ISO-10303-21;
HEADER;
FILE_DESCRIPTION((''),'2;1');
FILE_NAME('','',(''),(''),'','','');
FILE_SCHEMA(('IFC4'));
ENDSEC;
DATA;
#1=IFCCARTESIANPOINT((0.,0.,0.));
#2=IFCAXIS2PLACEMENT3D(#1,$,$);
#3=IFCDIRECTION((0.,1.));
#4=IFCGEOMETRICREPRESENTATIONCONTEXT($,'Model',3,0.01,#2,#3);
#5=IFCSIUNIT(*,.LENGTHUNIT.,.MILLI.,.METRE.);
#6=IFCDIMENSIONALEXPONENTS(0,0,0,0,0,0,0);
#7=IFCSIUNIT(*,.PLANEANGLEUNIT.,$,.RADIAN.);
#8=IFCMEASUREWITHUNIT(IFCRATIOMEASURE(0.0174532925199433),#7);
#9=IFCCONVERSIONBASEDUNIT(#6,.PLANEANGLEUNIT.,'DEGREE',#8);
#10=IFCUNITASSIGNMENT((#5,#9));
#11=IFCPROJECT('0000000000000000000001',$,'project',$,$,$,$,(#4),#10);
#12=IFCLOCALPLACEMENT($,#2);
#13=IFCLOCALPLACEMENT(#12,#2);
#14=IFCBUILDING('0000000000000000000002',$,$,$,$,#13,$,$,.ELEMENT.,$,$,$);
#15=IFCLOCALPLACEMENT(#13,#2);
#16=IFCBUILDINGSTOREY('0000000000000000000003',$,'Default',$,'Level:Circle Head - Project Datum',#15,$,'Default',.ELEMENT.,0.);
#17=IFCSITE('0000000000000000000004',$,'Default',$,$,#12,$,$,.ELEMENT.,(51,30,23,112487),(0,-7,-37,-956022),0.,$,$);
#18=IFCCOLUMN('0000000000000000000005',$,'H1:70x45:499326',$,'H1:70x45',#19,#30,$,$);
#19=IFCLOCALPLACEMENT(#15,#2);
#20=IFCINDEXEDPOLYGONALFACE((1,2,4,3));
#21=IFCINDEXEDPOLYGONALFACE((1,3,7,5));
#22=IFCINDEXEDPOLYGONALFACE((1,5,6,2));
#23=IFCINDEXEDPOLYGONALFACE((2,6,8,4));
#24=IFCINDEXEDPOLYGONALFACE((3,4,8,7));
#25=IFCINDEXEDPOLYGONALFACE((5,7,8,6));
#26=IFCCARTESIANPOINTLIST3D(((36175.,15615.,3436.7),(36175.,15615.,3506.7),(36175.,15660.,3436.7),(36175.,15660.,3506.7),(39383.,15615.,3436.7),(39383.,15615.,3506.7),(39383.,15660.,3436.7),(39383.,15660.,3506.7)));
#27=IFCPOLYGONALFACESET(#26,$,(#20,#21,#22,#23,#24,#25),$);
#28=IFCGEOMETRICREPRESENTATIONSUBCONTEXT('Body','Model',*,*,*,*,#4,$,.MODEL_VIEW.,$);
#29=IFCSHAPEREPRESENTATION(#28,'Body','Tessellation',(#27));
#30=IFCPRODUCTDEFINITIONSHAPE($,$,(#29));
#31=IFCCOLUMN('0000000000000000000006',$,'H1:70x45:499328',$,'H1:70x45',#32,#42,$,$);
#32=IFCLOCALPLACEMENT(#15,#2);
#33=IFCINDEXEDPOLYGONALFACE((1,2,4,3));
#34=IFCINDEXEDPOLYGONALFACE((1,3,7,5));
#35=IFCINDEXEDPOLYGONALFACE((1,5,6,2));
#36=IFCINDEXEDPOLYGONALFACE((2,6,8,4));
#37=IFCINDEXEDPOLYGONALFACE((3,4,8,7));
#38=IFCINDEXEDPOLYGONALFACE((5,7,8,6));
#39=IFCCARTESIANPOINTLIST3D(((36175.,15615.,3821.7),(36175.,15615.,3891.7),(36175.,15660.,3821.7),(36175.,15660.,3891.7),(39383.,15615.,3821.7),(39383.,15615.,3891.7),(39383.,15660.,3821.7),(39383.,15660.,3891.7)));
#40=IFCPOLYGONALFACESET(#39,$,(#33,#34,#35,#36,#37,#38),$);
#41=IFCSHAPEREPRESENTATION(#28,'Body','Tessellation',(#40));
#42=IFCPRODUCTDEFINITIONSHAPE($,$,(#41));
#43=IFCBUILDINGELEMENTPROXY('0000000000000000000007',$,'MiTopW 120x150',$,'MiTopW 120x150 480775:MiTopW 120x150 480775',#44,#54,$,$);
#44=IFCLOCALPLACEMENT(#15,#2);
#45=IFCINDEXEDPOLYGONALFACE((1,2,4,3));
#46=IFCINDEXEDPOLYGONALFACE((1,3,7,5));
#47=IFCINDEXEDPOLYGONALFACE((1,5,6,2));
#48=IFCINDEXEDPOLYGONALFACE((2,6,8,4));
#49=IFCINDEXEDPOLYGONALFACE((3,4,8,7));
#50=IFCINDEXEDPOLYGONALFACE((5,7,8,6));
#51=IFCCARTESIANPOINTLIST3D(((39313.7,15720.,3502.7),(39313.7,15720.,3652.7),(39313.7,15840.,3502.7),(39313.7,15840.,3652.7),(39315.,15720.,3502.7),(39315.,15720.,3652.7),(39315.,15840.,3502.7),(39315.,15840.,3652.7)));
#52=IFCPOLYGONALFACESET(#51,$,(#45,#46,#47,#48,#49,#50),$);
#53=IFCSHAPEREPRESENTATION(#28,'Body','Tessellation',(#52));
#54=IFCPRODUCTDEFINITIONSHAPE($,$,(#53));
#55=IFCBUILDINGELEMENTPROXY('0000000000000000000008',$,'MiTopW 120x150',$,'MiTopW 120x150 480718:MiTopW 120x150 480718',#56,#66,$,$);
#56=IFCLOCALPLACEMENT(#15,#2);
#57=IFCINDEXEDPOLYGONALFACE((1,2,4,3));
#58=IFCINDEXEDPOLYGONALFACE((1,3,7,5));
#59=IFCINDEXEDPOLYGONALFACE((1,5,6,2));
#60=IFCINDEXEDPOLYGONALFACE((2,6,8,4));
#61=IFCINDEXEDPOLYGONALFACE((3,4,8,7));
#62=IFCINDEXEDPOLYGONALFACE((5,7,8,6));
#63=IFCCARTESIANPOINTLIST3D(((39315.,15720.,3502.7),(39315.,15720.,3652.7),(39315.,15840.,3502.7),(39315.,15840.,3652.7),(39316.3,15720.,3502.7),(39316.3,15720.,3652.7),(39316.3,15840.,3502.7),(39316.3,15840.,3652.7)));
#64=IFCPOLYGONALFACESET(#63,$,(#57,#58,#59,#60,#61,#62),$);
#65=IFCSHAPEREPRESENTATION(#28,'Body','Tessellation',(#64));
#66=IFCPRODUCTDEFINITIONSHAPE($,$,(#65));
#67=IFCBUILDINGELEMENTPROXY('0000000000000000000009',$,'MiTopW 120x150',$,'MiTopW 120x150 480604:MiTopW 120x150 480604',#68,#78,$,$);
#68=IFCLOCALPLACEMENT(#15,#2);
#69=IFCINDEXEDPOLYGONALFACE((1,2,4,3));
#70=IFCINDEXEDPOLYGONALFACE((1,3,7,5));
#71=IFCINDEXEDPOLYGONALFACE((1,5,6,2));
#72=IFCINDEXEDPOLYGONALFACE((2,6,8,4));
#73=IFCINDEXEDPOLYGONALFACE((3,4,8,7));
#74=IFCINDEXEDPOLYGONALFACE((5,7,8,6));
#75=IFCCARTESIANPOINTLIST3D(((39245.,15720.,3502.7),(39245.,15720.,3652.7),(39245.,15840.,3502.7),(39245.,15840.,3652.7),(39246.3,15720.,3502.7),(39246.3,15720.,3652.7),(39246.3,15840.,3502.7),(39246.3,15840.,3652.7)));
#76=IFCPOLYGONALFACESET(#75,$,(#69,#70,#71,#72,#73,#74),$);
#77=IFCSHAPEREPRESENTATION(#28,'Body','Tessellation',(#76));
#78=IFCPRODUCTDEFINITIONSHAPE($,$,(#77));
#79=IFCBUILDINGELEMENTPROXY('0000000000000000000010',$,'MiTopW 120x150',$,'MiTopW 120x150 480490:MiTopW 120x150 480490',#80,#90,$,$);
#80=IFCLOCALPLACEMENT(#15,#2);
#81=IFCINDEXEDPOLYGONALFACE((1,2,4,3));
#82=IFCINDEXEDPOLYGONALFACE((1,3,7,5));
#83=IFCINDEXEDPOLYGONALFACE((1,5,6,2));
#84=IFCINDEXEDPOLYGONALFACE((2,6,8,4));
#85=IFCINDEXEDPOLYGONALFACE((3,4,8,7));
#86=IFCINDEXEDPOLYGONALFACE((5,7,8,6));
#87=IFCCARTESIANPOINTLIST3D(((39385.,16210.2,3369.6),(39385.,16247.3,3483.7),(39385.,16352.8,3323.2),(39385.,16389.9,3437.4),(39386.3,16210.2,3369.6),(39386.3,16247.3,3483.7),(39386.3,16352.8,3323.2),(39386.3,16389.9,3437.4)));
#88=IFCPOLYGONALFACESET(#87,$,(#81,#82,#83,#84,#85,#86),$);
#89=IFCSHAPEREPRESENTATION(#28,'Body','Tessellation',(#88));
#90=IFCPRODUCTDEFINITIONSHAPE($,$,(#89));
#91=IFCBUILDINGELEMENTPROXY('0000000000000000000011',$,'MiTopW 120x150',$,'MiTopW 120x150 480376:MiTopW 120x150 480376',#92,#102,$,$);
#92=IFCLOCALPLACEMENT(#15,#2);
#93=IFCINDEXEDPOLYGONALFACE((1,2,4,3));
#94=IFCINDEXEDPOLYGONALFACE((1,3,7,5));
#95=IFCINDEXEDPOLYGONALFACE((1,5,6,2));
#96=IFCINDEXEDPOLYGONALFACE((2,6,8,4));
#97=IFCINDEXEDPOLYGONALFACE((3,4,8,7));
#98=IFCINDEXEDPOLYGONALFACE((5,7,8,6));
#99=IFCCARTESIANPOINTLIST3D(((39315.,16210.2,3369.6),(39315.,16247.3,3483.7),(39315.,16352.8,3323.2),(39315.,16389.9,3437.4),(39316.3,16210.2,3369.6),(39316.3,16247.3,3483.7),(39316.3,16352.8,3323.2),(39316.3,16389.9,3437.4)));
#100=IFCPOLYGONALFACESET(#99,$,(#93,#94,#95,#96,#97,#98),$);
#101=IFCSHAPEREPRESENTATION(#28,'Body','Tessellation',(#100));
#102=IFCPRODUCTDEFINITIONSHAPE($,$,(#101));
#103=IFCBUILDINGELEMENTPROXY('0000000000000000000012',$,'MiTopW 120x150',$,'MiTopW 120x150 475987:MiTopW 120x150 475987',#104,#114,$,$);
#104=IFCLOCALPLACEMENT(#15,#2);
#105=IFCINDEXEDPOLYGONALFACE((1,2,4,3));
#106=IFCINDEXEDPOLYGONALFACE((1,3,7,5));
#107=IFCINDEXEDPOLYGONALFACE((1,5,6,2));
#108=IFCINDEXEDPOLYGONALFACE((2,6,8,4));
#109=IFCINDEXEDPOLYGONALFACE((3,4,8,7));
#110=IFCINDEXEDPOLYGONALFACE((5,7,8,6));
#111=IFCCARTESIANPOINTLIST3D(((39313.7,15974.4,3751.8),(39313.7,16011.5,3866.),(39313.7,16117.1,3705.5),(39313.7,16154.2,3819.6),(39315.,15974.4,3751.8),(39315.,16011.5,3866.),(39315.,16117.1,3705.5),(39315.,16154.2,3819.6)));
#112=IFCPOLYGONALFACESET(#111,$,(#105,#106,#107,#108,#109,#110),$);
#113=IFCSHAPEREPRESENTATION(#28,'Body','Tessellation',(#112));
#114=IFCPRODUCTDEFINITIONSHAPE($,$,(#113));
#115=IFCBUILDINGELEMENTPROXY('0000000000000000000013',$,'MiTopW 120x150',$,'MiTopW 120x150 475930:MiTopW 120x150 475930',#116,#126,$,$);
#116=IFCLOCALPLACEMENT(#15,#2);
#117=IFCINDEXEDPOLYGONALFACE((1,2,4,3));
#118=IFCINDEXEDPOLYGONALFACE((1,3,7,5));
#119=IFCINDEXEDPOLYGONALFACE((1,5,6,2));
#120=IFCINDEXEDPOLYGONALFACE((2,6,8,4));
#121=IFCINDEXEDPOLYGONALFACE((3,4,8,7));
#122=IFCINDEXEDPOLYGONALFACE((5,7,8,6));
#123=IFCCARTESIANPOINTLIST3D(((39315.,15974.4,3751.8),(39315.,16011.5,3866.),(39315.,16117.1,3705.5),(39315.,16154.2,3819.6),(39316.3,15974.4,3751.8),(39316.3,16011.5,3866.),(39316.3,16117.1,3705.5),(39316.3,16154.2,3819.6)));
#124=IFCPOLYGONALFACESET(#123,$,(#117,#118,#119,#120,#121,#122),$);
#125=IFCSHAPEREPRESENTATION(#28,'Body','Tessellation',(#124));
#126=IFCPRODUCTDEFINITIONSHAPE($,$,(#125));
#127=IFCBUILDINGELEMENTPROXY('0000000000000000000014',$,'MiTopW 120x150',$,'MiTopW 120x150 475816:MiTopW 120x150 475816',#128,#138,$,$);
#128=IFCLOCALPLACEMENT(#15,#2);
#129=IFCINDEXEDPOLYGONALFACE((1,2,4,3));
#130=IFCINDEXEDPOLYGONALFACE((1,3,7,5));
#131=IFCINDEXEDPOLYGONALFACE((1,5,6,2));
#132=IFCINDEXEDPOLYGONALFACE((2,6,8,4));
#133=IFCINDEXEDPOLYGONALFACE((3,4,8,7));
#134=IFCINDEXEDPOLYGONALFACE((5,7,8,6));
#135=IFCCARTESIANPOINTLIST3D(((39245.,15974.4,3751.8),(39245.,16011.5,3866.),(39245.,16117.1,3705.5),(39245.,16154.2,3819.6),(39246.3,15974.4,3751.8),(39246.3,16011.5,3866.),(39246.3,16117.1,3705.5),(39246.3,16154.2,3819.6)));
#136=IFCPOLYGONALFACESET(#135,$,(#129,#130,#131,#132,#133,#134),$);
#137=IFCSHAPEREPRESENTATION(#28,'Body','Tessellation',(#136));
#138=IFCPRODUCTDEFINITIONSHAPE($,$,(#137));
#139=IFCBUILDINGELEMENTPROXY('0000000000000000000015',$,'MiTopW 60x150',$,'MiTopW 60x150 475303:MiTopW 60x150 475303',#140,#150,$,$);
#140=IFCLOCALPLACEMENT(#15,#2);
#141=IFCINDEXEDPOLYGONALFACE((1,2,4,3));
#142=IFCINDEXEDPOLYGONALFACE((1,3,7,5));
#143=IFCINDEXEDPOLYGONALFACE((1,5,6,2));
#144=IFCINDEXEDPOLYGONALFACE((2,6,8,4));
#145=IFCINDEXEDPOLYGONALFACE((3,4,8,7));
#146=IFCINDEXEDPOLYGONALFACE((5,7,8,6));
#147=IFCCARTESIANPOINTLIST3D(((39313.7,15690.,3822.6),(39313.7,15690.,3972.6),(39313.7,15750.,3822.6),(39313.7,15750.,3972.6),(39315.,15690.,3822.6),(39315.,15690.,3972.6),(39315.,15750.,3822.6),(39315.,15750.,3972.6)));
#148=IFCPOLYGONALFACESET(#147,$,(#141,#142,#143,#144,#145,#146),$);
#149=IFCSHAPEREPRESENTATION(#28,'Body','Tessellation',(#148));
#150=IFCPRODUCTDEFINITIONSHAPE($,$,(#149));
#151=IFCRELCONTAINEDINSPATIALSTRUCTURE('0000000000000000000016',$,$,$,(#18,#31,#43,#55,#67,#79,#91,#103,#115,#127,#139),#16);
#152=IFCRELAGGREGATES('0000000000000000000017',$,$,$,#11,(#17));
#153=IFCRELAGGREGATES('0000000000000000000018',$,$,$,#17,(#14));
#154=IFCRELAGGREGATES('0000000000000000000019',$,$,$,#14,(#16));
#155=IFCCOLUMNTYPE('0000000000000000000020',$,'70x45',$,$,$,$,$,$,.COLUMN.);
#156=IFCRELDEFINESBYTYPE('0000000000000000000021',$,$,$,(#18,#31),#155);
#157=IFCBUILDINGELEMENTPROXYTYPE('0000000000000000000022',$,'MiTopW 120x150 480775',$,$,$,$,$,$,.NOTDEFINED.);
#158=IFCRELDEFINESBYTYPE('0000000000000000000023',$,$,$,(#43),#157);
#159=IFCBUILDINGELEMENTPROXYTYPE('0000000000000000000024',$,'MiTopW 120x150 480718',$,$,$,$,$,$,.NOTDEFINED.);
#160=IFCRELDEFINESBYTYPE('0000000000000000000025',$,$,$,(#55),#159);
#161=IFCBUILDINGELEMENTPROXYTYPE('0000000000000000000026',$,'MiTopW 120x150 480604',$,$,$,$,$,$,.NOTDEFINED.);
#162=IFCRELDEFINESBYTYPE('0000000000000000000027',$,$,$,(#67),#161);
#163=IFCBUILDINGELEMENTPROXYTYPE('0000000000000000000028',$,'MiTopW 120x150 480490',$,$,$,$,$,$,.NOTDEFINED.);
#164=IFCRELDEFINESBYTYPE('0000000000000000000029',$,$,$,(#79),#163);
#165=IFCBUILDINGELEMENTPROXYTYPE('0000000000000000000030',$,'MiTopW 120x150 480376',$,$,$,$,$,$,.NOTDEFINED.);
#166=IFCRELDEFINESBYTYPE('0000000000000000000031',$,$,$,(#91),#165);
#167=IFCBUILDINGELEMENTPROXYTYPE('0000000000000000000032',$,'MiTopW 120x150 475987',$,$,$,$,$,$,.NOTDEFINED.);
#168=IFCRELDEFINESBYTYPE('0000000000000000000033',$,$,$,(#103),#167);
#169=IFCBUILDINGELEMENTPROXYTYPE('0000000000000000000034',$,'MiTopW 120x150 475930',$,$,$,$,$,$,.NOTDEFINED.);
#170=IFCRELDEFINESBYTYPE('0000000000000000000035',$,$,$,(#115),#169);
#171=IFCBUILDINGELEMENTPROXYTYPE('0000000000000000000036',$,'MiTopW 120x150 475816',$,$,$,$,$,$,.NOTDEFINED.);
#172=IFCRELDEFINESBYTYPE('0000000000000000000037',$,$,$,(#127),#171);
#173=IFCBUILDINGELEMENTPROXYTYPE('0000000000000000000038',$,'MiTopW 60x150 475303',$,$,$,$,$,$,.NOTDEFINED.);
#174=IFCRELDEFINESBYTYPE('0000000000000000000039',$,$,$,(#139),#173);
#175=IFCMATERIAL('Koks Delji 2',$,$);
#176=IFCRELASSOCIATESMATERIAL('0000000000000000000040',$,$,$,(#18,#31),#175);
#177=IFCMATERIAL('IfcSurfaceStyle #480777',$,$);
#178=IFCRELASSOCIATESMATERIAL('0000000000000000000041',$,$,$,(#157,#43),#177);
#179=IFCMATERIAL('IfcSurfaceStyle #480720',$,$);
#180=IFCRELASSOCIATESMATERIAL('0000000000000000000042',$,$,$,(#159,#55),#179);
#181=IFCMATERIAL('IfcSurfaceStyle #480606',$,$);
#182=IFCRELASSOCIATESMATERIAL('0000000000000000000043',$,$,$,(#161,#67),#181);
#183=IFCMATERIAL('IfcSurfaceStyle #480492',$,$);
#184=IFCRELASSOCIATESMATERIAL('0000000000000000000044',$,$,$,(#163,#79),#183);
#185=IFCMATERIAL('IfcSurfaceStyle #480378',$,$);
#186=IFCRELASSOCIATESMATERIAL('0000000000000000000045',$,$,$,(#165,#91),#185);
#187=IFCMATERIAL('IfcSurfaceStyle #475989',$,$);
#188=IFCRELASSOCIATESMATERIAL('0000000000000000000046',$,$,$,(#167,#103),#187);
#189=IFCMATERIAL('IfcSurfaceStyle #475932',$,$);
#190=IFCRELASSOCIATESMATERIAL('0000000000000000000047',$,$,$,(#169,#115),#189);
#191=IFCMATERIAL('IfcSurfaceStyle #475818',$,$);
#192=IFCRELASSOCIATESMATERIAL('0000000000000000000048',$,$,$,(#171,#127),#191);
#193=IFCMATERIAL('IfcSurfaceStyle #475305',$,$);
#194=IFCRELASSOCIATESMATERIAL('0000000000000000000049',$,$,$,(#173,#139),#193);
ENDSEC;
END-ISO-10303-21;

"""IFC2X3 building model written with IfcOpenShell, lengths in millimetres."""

from ifc_helpers import new_model, entity, si_unit, converted_unit, direction, frame, frame_2d, origin, origin_2d_with_axis, place, context, subcontext, project, spatial, polyline, rectangle, outline, extrude, source, transform, mapped, material, type_object, type_shapes, element, save


model = new_model("IFC2X3")

# Units and contexts
model_context = context("Model", 3, precision=0.01, world=origin(), true_north=direction((0.0, 1.0)))
body_context = subcontext(model_context, "Body", "Model", "MODEL_VIEW")
ifc_project = project(units=[si_unit("LENGTHUNIT", "METRE", prefix="MILLI"), converted_unit("PLANEANGLEUNIT", "DEGREE", entity("IfcRatioMeasure", 0.0174532925199433), si_unit("PLANEANGLEUNIT", "RADIAN"), dimensions=[0, 0, 0, 0, 0, 0, 0])], contexts=[model_context])

# Site, building, storey
site_placement = place(None, origin())
site = spatial("IfcSite", under=ifc_project, at=site_placement, Name="Default", CompositionType="ELEMENT", RefLatitude=(51, 30, 23, 112487), RefLongitude=(0, -7, -37, -956022), RefElevation=0.0)
building_placement = place(site_placement, origin())
building = spatial("IfcBuilding", under=site, at=building_placement, CompositionType="ELEMENT")
storey_placement = place(building_placement, origin())
storey = spatial("IfcBuildingStorey", under=building, at=storey_placement, Name="Default", ObjectType="Level:Circle Head - Project Datum", LongName="Default", CompositionType="ELEMENT", Elevation=0.0)

# Columns
ifc_material_1 = material(Name="Koks Delji 2")
column_type = type_object("IfcColumnType", Name="70x45", PredefinedType="COLUMN")
shared_shape_1 = source(origin(), body_context, "Body", "SweptSolid", [
    extrude(rectangle(XDim=45.0, YDim=3208.0, at=frame_2d((0.0, 0.0), x_axis=(1.0, 0.0))), frame((1604.0, 250.3, 0.0), z_axis=(0.0, 0.0, 1.0), x_axis=(0.0, -1.0, 0.0)), (0.0, 0.0, 1.0), 70.0),
])
type_shapes(column_type, [shared_shape_1])
for number, where, z_axis, x_axis, name in (
    (1, (39383.0, 15887.8, 3436.7), (0.0, 0.0, 1.0), (-1.0, 0.0, 0.0), "H1:70x45:499326"),
    (2, (39383.0, 15887.8, 3821.7), (0.0, 0.0, 1.0), (-1.0, 0.0, 0.0), "H1:70x45:499328"),
):
    element("IfcColumn", number, at=place(storey_placement, frame(where, z_axis=z_axis, x_axis=x_axis)), inside=storey, type_object=column_type, material=ifc_material_1, Name=name, ObjectType="H1:70x45", context=body_context, shape_type="MappedRepresentation", body=[
        mapped(shared_shape_1, transform((0.0, 0.0, 0.0), scale=1.0)),
    ])

# Building element proxies
ifc_material_2 = material(Name="IfcSurfaceStyle #480777")
building_element_proxy_type_1 = type_object("IfcBuildingElementProxyType", Name="MiTopW 120x150 480775", PredefinedType="NOTDEFINED", material=ifc_material_2)
shared_shape_2 = source(origin(), body_context, "Body", "SweptSolid", [
    extrude(rectangle(XDim=150.0, YDim=120.0, at=origin_2d_with_axis()), frame((75.0, 60.0, 0.0), z_axis=(0.0, 0.0, 1.0), x_axis=(-1.0, 0.0, 0.0)), (0.0, 0.0, 1.0), 1.3),
])
type_shapes(building_element_proxy_type_1, [shared_shape_2])
proxy_1_placement = place(building_placement, frame((39315.0, 15840.0, 3652.7), z_axis=(-1.0, 0.0, 0.0), x_axis=(0.0, 0.0, -1.0)))
element("IfcBuildingElementProxy", 3, at=proxy_1_placement, inside=storey, type_object=building_element_proxy_type_1, material=ifc_material_2, Name="MiTopW 120x150", ObjectType="MiTopW 120x150 480775:MiTopW 120x150 480775", context=body_context, shape_type="MappedRepresentation", body=[
    mapped(shared_shape_2, transform((0.0, 0.0, 0.0), scale=1.0)),
])
ifc_material_3 = material(Name="IfcSurfaceStyle #480720")
building_element_proxy_type_2 = type_object("IfcBuildingElementProxyType", Name="MiTopW 120x150 480718", PredefinedType="NOTDEFINED", material=ifc_material_3)
shared_shape_3 = source(origin(), body_context, "Body", "SweptSolid", [
    extrude(rectangle(XDim=150.0, YDim=120.0, at=origin_2d_with_axis()), frame((75.0, 60.0, 0.0), z_axis=(0.0, 0.0, 1.0), x_axis=(-1.0, 0.0, 0.0)), (0.0, 0.0, 1.0), 1.3),
])
type_shapes(building_element_proxy_type_2, [shared_shape_3])
proxy_2_placement = place(building_placement, frame((39316.3, 15840.0, 3652.7), z_axis=(-1.0, 0.0, 0.0), x_axis=(0.0, 0.0, -1.0)))
element("IfcBuildingElementProxy", 4, at=proxy_2_placement, inside=storey, type_object=building_element_proxy_type_2, material=ifc_material_3, Name="MiTopW 120x150", ObjectType="MiTopW 120x150 480718:MiTopW 120x150 480718", context=body_context, shape_type="MappedRepresentation", body=[
    mapped(shared_shape_3, transform((0.0, 0.0, 0.0), scale=1.0)),
])
ifc_material_4 = material(Name="IfcSurfaceStyle #480606")
building_element_proxy_type_3 = type_object("IfcBuildingElementProxyType", Name="MiTopW 120x150 480604", PredefinedType="NOTDEFINED", material=ifc_material_4)
shared_shape_4 = source(origin(), body_context, "Body", "SweptSolid", [
    extrude(rectangle(XDim=150.0, YDim=120.0, at=origin_2d_with_axis()), frame((75.0, 60.0, 0.0), z_axis=(0.0, 0.0, 1.0), x_axis=(-1.0, 0.0, 0.0)), (0.0, 0.0, 1.0), 1.3),
])
type_shapes(building_element_proxy_type_3, [shared_shape_4])
proxy_3_placement = place(building_placement, frame((39246.3, 15840.0, 3652.7), z_axis=(-1.0, 0.0, 0.0), x_axis=(0.0, 0.0, -1.0)))
element("IfcBuildingElementProxy", 5, at=proxy_3_placement, inside=storey, type_object=building_element_proxy_type_3, material=ifc_material_4, Name="MiTopW 120x150", ObjectType="MiTopW 120x150 480604:MiTopW 120x150 480604", context=body_context, shape_type="MappedRepresentation", body=[
    mapped(shared_shape_4, transform((0.0, 0.0, 0.0), scale=1.0)),
])
ifc_material_5 = material(Name="IfcSurfaceStyle #480492")
building_element_proxy_type_4 = type_object("IfcBuildingElementProxyType", Name="MiTopW 120x150 480490", PredefinedType="NOTDEFINED", material=ifc_material_5)
shared_shape_5 = source(origin(), body_context, "Body", "SweptSolid", [
    extrude(outline(polyline([(-75.0, -60.0), (75.0, -60.0), (75.0, 60.0), (-75.0, 60.0), (-75.0, -60.0)])), frame((75.0, 60.0, 0.0), z_axis=(0.0, 0.0, 1.0), x_axis=(-1.0, 0.0, 0.0)), (0.0, 0.0, 1.0), 1.3),
])
type_shapes(building_element_proxy_type_4, [shared_shape_5])
proxy_4_placement = place(building_placement, frame((39386.3, 16352.8, 3323.2), z_axis=(-1.0, 0.0, 0.0), x_axis=(0.0, -0.951057, 0.309017)))
element("IfcBuildingElementProxy", 6, at=proxy_4_placement, inside=storey, type_object=building_element_proxy_type_4, material=ifc_material_5, Name="MiTopW 120x150", ObjectType="MiTopW 120x150 480490:MiTopW 120x150 480490", context=body_context, shape_type="MappedRepresentation", body=[
    mapped(shared_shape_5, transform((0.0, 0.0, 0.0), scale=1.0)),
])
ifc_material_6 = material(Name="IfcSurfaceStyle #480378")
building_element_proxy_type_5 = type_object("IfcBuildingElementProxyType", Name="MiTopW 120x150 480376", PredefinedType="NOTDEFINED", material=ifc_material_6)
shared_shape_6 = source(origin(), body_context, "Body", "SweptSolid", [
    extrude(outline(polyline([(-75.0, -60.0), (75.0, -60.0), (75.0, 60.0), (-75.0, 60.0), (-75.0, -60.0)])), frame((75.0, 60.0, 0.0), z_axis=(0.0, 0.0, 1.0), x_axis=(-1.0, 0.0, 0.0)), (0.0, 0.0, 1.0), 1.3),
])
type_shapes(building_element_proxy_type_5, [shared_shape_6])
proxy_5_placement = place(building_placement, frame((39316.3, 16352.8, 3323.2), z_axis=(-1.0, 0.0, 0.0), x_axis=(0.0, -0.951057, 0.309017)))
element("IfcBuildingElementProxy", 7, at=proxy_5_placement, inside=storey, type_object=building_element_proxy_type_5, material=ifc_material_6, Name="MiTopW 120x150", ObjectType="MiTopW 120x150 480376:MiTopW 120x150 480376", context=body_context, shape_type="MappedRepresentation", body=[
    mapped(shared_shape_6, transform((0.0, 0.0, 0.0), scale=1.0)),
])
ifc_material_7 = material(Name="IfcSurfaceStyle #475989")
building_element_proxy_type_6 = type_object("IfcBuildingElementProxyType", Name="MiTopW 120x150 475987", PredefinedType="NOTDEFINED", material=ifc_material_7)
shared_shape_7 = source(origin(), body_context, "Body", "SweptSolid", [
    extrude(outline(polyline([(-75.0, -60.0), (75.0, -60.0), (75.0, 60.0), (-75.0, 60.0), (-75.0, -60.0)])), frame((75.0, 60.0, 0.0), z_axis=(0.0, 0.0, 1.0), x_axis=(-1.0, 0.0, 0.0)), (0.0, 0.0, 1.0), 1.3),
])
type_shapes(building_element_proxy_type_6, [shared_shape_7])
proxy_6_placement = place(building_placement, frame((39315.0, 16117.1, 3705.5), z_axis=(-1.0, 0.0, 0.0), x_axis=(0.0, -0.951057, 0.309017)))
element("IfcBuildingElementProxy", 8, at=proxy_6_placement, inside=storey, type_object=building_element_proxy_type_6, material=ifc_material_7, Name="MiTopW 120x150", ObjectType="MiTopW 120x150 475987:MiTopW 120x150 475987", context=body_context, shape_type="MappedRepresentation", body=[
    mapped(shared_shape_7, transform((0.0, 0.0, 0.0), scale=1.0)),
])
ifc_material_8 = material(Name="IfcSurfaceStyle #475932")
building_element_proxy_type_7 = type_object("IfcBuildingElementProxyType", Name="MiTopW 120x150 475930", PredefinedType="NOTDEFINED", material=ifc_material_8)
shared_shape_8 = source(origin(), body_context, "Body", "SweptSolid", [
    extrude(outline(polyline([(-75.0, -60.0), (75.0, -60.0), (75.0, 60.0), (-75.0, 60.0), (-75.0, -60.0)])), frame((75.0, 60.0, 0.0), z_axis=(0.0, 0.0, 1.0), x_axis=(-1.0, 0.0, 0.0)), (0.0, 0.0, 1.0), 1.3),
])
type_shapes(building_element_proxy_type_7, [shared_shape_8])
proxy_7_placement = place(building_placement, frame((39316.3, 16117.1, 3705.5), z_axis=(-1.0, 0.0, 0.0), x_axis=(0.0, -0.951057, 0.309017)))
element("IfcBuildingElementProxy", 9, at=proxy_7_placement, inside=storey, type_object=building_element_proxy_type_7, material=ifc_material_8, Name="MiTopW 120x150", ObjectType="MiTopW 120x150 475930:MiTopW 120x150 475930", context=body_context, shape_type="MappedRepresentation", body=[
    mapped(shared_shape_8, transform((0.0, 0.0, 0.0), scale=1.0)),
])
ifc_material_9 = material(Name="IfcSurfaceStyle #475818")
building_element_proxy_type_8 = type_object("IfcBuildingElementProxyType", Name="MiTopW 120x150 475816", PredefinedType="NOTDEFINED", material=ifc_material_9)
shared_shape_9 = source(origin(), body_context, "Body", "SweptSolid", [
    extrude(outline(polyline([(-75.0, -60.0), (75.0, -60.0), (75.0, 60.0), (-75.0, 60.0), (-75.0, -60.0)])), frame((75.0, 60.0, 0.0), z_axis=(0.0, 0.0, 1.0), x_axis=(-1.0, 0.0, 0.0)), (0.0, 0.0, 1.0), 1.3),
])
type_shapes(building_element_proxy_type_8, [shared_shape_9])
proxy_8_placement = place(building_placement, frame((39246.3, 16117.1, 3705.5), z_axis=(-1.0, 0.0, 0.0), x_axis=(0.0, -0.951057, 0.309017)))
element("IfcBuildingElementProxy", 10, at=proxy_8_placement, inside=storey, type_object=building_element_proxy_type_8, material=ifc_material_9, Name="MiTopW 120x150", ObjectType="MiTopW 120x150 475816:MiTopW 120x150 475816", context=body_context, shape_type="MappedRepresentation", body=[
    mapped(shared_shape_9, transform((0.0, 0.0, 0.0), scale=1.0)),
])
ifc_material_10 = material(Name="IfcSurfaceStyle #475305")
building_element_proxy_type_9 = type_object("IfcBuildingElementProxyType", Name="MiTopW 60x150 475303", PredefinedType="NOTDEFINED", material=ifc_material_10)
shared_shape_10 = source(origin(), body_context, "Body", "SweptSolid", [
    extrude(rectangle(XDim=150.0, YDim=60.0, at=origin_2d_with_axis()), frame((75.0, 30.0, 0.0), z_axis=(0.0, 0.0, 1.0), x_axis=(-1.0, 0.0, 0.0)), (0.0, 0.0, 1.0), 1.3),
])
type_shapes(building_element_proxy_type_9, [shared_shape_10])
proxy_9_placement = place(building_placement, frame((39315.0, 15750.0, 3972.6), z_axis=(-1.0, 0.0, 0.0), x_axis=(0.0, 0.0, -1.0)))
element("IfcBuildingElementProxy", 11, at=proxy_9_placement, inside=storey, type_object=building_element_proxy_type_9, material=ifc_material_10, Name="MiTopW 60x150", ObjectType="MiTopW 60x150 475303:MiTopW 60x150 475303", context=body_context, shape_type="MappedRepresentation", body=[
    mapped(shared_shape_10, transform((0.0, 0.0, 0.0), scale=1.0)),
])

save(model, "model.ifc")
